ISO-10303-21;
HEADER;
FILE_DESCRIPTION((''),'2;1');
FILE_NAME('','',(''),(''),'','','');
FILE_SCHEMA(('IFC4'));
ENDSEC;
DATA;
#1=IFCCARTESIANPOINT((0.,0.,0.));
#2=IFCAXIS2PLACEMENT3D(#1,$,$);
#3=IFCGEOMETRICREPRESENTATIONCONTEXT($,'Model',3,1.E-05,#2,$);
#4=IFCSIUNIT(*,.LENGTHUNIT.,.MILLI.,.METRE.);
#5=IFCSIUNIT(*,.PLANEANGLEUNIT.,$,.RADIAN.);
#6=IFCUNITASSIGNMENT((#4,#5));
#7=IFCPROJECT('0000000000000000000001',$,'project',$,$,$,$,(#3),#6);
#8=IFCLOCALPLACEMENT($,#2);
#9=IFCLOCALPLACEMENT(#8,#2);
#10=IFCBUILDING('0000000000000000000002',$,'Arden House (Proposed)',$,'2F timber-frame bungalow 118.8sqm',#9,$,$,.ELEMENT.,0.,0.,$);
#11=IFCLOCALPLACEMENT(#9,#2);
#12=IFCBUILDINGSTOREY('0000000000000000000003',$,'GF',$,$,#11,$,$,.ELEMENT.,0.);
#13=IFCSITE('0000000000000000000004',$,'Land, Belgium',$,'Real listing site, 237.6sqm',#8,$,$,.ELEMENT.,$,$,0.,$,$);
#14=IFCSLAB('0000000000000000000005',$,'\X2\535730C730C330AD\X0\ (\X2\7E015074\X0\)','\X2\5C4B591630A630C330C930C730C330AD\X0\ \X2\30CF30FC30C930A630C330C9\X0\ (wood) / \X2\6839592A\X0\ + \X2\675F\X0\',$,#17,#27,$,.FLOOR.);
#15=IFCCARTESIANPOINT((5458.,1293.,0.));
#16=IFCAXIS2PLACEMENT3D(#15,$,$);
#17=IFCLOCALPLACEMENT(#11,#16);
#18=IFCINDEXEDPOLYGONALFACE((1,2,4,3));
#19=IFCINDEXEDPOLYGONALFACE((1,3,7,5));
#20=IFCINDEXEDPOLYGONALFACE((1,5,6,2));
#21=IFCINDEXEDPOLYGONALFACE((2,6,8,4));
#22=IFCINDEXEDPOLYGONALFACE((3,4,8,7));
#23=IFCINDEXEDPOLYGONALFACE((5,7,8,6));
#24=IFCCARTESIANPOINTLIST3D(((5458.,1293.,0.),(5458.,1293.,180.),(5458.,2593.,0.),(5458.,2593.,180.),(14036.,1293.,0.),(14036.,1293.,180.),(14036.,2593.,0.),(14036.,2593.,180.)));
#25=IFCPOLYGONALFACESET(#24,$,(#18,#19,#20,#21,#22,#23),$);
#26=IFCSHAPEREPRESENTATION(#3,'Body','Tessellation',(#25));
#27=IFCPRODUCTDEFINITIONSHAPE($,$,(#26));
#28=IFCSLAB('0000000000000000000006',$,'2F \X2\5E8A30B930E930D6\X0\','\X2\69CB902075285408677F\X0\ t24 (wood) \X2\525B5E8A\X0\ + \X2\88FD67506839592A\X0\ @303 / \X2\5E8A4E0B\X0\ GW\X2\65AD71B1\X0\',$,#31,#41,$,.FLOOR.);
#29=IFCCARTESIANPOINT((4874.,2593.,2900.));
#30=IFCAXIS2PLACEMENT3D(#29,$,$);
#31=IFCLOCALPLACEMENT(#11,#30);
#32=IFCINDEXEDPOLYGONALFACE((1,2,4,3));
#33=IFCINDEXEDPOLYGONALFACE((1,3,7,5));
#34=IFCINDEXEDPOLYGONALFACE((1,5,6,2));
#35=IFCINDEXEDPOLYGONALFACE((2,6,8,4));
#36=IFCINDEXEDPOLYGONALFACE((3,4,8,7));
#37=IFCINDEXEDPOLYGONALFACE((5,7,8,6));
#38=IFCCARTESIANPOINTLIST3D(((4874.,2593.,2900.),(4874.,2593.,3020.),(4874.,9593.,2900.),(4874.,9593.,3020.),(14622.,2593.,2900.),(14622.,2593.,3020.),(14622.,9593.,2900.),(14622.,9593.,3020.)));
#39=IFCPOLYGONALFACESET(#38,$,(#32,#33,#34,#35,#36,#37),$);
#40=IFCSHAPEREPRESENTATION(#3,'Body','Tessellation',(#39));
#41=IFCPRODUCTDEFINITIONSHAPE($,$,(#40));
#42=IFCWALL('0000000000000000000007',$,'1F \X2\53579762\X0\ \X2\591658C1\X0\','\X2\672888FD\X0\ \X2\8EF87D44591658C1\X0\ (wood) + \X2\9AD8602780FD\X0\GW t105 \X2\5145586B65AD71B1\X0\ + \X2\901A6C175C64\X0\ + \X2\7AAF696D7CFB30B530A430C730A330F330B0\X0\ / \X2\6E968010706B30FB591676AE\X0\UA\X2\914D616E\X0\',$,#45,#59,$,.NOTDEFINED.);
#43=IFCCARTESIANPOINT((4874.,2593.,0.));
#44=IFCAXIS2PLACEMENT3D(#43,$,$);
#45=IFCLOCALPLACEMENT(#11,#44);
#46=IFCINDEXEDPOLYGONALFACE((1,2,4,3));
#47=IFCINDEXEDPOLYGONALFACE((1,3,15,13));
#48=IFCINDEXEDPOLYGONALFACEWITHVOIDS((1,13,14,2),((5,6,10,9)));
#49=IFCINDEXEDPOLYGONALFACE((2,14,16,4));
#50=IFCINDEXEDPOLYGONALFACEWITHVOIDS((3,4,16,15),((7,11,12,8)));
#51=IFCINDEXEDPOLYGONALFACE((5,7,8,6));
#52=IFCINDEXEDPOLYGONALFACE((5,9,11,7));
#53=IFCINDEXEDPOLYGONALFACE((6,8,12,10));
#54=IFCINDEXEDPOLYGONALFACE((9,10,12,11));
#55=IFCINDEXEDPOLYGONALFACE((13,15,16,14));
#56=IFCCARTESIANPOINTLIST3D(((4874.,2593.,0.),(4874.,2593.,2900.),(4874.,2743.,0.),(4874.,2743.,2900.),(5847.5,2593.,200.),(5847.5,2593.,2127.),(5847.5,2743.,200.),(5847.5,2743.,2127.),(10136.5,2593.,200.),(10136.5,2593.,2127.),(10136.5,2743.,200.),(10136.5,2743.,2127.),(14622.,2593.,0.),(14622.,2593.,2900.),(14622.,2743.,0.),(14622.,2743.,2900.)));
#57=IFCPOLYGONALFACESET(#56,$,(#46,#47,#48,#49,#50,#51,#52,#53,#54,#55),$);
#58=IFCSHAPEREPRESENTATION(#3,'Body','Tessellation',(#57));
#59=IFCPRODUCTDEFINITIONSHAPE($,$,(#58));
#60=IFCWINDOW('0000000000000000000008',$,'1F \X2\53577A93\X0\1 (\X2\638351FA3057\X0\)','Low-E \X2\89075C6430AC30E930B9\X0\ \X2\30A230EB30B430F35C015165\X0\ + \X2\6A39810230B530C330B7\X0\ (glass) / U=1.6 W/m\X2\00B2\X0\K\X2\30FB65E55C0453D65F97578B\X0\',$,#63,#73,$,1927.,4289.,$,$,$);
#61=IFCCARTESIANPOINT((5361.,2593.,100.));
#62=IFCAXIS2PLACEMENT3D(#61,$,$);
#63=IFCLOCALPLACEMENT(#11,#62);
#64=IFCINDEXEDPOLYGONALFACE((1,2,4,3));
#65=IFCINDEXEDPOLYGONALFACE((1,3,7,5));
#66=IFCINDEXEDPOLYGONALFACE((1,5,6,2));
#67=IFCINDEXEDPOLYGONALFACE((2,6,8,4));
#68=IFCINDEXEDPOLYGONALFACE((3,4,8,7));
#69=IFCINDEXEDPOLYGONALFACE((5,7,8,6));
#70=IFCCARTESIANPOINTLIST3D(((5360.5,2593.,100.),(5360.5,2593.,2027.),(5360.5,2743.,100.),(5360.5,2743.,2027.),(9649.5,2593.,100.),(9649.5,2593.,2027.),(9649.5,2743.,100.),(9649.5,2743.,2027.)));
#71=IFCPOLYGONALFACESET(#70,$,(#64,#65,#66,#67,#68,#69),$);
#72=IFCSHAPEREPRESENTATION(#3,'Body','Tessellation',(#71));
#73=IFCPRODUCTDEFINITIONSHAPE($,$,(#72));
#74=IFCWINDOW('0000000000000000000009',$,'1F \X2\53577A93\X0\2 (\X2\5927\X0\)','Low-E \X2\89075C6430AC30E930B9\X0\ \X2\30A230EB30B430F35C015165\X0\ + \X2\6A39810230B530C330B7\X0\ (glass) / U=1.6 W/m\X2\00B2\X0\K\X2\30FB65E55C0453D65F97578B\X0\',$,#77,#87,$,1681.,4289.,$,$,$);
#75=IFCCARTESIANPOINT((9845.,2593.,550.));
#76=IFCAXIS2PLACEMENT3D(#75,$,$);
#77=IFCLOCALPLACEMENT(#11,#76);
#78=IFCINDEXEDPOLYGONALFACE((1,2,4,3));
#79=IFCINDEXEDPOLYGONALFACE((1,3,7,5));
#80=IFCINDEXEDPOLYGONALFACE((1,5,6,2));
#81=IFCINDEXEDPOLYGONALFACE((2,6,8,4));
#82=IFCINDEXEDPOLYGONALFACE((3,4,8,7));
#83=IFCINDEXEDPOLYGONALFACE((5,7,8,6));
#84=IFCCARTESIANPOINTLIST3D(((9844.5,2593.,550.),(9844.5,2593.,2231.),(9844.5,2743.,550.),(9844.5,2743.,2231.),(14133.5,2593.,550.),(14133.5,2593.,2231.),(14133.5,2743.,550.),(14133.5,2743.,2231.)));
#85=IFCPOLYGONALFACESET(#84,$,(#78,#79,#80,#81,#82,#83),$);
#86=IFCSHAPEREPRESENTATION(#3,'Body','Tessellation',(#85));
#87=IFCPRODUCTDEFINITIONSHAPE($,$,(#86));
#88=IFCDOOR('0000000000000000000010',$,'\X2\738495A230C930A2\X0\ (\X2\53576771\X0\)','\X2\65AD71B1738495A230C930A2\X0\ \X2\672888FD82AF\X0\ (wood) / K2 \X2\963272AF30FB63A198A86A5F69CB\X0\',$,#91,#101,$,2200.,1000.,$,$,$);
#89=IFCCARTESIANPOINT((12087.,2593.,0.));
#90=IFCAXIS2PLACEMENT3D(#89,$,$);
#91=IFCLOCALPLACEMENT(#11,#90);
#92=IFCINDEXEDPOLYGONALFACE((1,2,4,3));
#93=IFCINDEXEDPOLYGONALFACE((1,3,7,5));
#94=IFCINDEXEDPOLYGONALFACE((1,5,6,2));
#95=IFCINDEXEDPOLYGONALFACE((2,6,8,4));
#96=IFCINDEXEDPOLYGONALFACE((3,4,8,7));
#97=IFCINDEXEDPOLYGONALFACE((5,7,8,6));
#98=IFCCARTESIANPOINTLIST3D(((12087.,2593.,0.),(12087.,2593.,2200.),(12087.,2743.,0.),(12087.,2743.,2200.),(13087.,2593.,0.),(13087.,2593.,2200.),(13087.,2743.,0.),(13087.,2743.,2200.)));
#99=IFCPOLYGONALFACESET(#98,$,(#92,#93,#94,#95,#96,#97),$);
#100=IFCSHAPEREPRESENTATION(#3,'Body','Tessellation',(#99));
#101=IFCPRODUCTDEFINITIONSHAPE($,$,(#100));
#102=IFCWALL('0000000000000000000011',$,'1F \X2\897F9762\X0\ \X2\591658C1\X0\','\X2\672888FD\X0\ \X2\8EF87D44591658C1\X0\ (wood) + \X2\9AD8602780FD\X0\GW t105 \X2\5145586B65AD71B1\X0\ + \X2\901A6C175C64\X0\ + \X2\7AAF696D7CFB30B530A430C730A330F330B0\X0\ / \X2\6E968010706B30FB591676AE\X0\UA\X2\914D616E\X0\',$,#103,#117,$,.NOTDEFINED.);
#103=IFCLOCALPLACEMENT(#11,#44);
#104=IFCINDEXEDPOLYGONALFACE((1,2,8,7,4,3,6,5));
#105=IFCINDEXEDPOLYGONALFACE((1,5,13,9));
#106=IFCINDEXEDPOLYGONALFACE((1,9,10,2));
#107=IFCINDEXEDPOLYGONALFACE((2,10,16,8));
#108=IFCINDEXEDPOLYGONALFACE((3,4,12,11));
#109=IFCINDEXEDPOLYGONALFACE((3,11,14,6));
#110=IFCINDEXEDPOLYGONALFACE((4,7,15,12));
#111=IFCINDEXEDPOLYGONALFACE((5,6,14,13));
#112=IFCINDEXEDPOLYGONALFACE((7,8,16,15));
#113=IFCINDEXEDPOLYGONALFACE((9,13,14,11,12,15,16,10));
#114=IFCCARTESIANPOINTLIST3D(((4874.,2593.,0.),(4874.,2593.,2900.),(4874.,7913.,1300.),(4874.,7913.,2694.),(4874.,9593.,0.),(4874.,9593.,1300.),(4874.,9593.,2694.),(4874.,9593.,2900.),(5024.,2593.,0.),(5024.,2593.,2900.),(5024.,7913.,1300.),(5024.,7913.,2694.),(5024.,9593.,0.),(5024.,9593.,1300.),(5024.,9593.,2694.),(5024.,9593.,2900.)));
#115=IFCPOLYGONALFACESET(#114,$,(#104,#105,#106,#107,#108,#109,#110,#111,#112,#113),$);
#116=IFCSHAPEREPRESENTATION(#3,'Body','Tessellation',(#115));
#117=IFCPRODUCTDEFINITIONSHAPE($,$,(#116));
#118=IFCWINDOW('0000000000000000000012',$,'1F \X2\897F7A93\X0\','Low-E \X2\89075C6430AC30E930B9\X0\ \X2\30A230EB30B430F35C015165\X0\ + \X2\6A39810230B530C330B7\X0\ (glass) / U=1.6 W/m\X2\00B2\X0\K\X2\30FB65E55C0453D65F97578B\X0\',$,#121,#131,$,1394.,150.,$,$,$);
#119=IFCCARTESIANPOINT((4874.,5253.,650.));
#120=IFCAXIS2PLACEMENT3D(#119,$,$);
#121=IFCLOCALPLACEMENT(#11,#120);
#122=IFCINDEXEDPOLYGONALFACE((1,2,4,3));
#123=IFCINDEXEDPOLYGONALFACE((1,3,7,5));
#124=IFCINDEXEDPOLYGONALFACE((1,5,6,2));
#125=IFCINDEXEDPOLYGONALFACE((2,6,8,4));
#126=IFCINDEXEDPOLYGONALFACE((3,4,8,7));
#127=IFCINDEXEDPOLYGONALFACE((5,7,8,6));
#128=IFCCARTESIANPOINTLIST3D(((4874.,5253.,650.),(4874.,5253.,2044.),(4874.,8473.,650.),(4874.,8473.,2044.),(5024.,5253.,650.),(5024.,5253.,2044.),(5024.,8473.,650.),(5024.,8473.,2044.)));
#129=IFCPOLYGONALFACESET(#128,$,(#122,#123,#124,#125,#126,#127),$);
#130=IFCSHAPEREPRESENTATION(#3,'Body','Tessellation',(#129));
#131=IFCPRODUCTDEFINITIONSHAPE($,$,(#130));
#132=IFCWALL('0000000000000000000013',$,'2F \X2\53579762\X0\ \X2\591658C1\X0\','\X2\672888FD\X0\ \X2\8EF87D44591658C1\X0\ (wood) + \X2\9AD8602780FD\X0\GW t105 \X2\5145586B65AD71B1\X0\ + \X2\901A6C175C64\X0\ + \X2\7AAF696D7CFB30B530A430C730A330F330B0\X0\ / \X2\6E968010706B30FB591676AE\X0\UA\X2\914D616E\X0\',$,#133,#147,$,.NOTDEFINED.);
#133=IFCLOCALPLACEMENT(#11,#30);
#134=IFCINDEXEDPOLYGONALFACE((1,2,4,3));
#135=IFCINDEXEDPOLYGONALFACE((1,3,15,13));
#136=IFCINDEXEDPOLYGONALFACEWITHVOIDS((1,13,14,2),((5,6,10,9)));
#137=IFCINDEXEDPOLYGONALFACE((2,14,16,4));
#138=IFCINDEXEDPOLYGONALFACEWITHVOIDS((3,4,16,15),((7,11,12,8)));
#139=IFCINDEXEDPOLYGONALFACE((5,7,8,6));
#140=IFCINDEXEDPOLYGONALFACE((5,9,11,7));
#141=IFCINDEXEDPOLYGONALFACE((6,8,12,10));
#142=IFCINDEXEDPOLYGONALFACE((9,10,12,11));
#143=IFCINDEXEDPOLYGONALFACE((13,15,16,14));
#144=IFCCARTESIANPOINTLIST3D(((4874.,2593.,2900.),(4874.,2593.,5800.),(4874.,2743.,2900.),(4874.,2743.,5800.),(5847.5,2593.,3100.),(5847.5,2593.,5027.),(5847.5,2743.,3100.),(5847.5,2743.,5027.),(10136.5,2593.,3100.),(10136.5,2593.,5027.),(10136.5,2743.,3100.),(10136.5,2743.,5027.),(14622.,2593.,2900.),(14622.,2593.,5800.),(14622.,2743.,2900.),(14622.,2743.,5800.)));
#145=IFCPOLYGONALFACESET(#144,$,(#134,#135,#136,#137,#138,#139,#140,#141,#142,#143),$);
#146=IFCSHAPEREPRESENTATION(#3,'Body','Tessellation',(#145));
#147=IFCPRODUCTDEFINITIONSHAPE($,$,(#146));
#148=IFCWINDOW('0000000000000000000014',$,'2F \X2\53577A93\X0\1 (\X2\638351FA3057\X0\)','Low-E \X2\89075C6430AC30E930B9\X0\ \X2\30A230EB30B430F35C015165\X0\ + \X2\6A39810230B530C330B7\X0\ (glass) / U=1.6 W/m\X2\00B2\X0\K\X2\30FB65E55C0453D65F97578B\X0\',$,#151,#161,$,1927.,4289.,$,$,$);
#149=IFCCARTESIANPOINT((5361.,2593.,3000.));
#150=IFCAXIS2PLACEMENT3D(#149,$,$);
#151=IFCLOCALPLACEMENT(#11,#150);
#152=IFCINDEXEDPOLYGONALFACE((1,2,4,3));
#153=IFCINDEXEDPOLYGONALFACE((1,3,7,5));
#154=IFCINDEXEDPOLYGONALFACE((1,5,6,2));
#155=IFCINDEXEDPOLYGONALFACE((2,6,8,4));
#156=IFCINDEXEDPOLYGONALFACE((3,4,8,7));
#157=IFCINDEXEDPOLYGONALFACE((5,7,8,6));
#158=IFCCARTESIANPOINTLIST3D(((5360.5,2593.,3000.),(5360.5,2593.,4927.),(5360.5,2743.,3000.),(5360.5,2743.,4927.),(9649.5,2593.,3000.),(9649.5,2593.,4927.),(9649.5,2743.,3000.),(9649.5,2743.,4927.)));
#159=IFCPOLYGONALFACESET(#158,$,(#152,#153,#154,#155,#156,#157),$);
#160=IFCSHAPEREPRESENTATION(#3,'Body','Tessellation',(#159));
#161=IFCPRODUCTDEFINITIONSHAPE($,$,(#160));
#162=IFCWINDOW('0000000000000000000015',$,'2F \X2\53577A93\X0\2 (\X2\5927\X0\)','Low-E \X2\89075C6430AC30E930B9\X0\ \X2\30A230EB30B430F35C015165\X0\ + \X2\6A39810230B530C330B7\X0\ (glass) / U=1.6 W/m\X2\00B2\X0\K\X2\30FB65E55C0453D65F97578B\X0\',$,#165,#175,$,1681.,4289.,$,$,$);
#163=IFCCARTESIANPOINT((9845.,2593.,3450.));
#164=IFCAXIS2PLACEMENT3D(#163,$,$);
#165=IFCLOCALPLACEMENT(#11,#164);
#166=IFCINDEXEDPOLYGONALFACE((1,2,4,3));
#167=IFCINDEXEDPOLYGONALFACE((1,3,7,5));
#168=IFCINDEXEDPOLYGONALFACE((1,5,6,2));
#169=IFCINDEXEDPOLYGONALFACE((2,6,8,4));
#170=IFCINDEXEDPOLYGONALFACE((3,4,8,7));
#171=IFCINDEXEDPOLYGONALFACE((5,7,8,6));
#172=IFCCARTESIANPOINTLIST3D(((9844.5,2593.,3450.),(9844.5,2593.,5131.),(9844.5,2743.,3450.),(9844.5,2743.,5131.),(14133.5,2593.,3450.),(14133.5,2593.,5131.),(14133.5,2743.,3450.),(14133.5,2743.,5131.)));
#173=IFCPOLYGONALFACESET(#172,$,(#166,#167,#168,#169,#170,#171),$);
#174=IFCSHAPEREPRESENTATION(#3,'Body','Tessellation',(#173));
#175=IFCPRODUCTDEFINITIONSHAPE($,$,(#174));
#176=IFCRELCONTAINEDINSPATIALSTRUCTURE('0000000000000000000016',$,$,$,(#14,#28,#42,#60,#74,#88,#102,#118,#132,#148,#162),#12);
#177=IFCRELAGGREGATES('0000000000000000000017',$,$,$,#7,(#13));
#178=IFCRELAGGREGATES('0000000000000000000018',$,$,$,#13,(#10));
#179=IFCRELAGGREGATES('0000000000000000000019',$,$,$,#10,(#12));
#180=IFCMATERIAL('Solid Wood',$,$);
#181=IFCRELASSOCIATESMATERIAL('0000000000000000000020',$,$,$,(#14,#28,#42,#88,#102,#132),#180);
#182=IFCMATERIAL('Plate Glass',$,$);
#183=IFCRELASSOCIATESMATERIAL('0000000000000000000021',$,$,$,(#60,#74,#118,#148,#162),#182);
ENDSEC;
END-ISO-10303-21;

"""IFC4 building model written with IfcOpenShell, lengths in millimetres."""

from ifc_helpers import new_model, si_unit, frame, frame_2d, origin, place, context, project, spatial, rectangle, extrude, material, element, fill, save


model = new_model("IFC4")

# Units and contexts
model_context = context("Model", 3, precision=1e-05, world=origin())
ifc_project = project(units=[si_unit("LENGTHUNIT", "METRE", prefix="MILLI"), si_unit("PLANEANGLEUNIT", "RADIAN")], contexts=[model_context])

# Site, building, storey
site_placement = place(None, origin())
site = spatial("IfcSite", under=ifc_project, at=site_placement, Name="Land, Belgium", ObjectType="Real listing site, 237.6sqm", CompositionType="ELEMENT", RefElevation=0.0)
building_placement = place(site_placement, origin())
building = spatial("IfcBuilding", under=site, at=building_placement, Name="Arden House (Proposed)", ObjectType="2F timber-frame bungalow 118.8sqm", CompositionType="ELEMENT", ElevationOfRefHeight=0.0, ElevationOfTerrain=0.0)
storey_placement = place(building_placement, origin())
storey = spatial("IfcBuildingStorey", under=building, at=storey_placement, Name="GF", CompositionType="ELEMENT", Elevation=0.0)

# Slabs
ifc_material_1 = material(Name="Solid Wood")
slab_1_placement = place(storey_placement, frame((5458.0, 1293.0, 0.0)))
element("IfcSlab", 1, at=slab_1_placement, inside=storey, material=ifc_material_1, Name="南デッキ (縁側)", Description="屋外ウッドデッキ ハードウッド (wood) / 根太 + 束", PredefinedType="FLOOR", context=model_context, shape_type="SweptSolid", body=[
    extrude(rectangle(XDim=8578.0, YDim=1300.0, at=frame_2d((4289.0, 650.0))), frame((5458.0, 1293.0, 0.0)), (0.0, 0.0, 1.0), 180.0),
])
slab_2_placement = place(storey_placement, frame((4874.0, 2593.0, 2900.0)))
element("IfcSlab", 2, at=slab_2_placement, inside=storey, material=ifc_material_1, Name="2F 床スラブ", Description="構造用合板 t24 (wood) 剛床 + 製材根太 @303 / 床下 GW断熱", PredefinedType="FLOOR", context=model_context, shape_type="SweptSolid", body=[
    extrude(rectangle(XDim=9748.0, YDim=7000.0, at=frame_2d((4874.0, 3500.0))), frame((4874.0, 2593.0, 2900.0)), (0.0, 0.0, 1.0), 120.0),
])

# Wall, openings, windows, door
wall_1_placement = place(storey_placement, frame((4874.0, 2593.0, 0.0)))
wall_1 = element("IfcWall", 3, at=wall_1_placement, inside=storey, material=ifc_material_1, Name="1F 南面 外壁", Description="木製 軸組外壁 (wood) + 高性能GW t105 充填断熱 + 通気層 + 窯業系サイディング / 準耐火・外皮UA配慮", PredefinedType="NOTDEFINED", context=model_context, shape_type="SweptSolid", body=[
    extrude(rectangle(XDim=9748.0, YDim=150.0, at=frame_2d((4874.0, 75.0))), frame((4874.0, 2593.0, 0.0)), (0.0, 0.0, 1.0), 2900.0),
])
opening_1_placement = place(storey_placement, frame((5361.0, 2593.0, 100.0)))
opening_1 = element("IfcOpeningElement", 4, at=opening_1_placement, cuts=wall_1, PredefinedType="NOTDEFINED", context=model_context, shape_type="SweptSolid", body=[
    extrude(rectangle(XDim=4289.0, YDim=150.0, at=frame_2d((2144.0, 75.0))), frame((5361.0, 2593.0, 100.0)), (0.0, 0.0, 1.0), 1927.0),
])
opening_2_placement = place(storey_placement, frame((9845.0, 2593.0, 550.0)))
opening_2 = element("IfcOpeningElement", 5, at=opening_2_placement, cuts=wall_1, PredefinedType="NOTDEFINED", context=model_context, shape_type="SweptSolid", body=[
    extrude(rectangle(XDim=4289.0, YDim=150.0, at=frame_2d((2144.0, 75.0))), frame((9845.0, 2593.0, 550.0)), (0.0, 0.0, 1.0), 1681.0),
])
opening_3_placement = place(storey_placement, frame((12087.0, 2593.0, 0.0)))
opening_3 = element("IfcOpeningElement", 6, at=opening_3_placement, cuts=wall_1, PredefinedType="NOTDEFINED", context=model_context, shape_type="SweptSolid", body=[
    extrude(rectangle(XDim=1000.0, YDim=150.0, at=frame_2d((500.0, 75.0))), frame((12087.0, 2593.0, 0.0)), (0.0, 0.0, 1.0), 2200.0),
])
ifc_material_2 = material(Name="Plate Glass")
window_1_placement = place(storey_placement, frame((5361.0, 2593.0, 100.0)))
window_1 = element("IfcWindow", 7, at=window_1_placement, inside=storey, material=ifc_material_2, Name="1F 南窓1 (掃出し)", Description="Low-E 複層ガラス アルゴン封入 + 樹脂サッシ (glass) / U=1.6 W/m²K・日射取得型", OverallHeight=1927.0, OverallWidth=4289.0, context=model_context, shape_type="SweptSolid", body=[
    extrude(rectangle(XDim=4289.0, YDim=150.0, at=frame_2d((2144.0, 75.0))), frame((5361.0, 2593.0, 100.0)), (0.0, 0.0, 1.0), 1927.0),
])
fill(opening_1, window_1)
window_2_placement = place(storey_placement, frame((9845.0, 2593.0, 550.0)))
window_2 = element("IfcWindow", 8, at=window_2_placement, inside=storey, material=ifc_material_2, Name="1F 南窓2 (大)", Description="Low-E 複層ガラス アルゴン封入 + 樹脂サッシ (glass) / U=1.6 W/m²K・日射取得型", OverallHeight=1681.0, OverallWidth=4289.0, context=model_context, shape_type="SweptSolid", body=[
    extrude(rectangle(XDim=4289.0, YDim=150.0, at=frame_2d((2144.0, 75.0))), frame((9845.0, 2593.0, 550.0)), (0.0, 0.0, 1.0), 1681.0),
])
fill(opening_2, window_2)
door_placement = place(storey_placement, frame((12087.0, 2593.0, 0.0)))
door = element("IfcDoor", 9, at=door_placement, inside=storey, material=ifc_material_1, Name="玄関ドア (南東)", Description="断熱玄関ドア 木製芯 (wood) / K2 防犯・採風機構", OverallHeight=2200.0, OverallWidth=1000.0, context=model_context, shape_type="SweptSolid", body=[
    extrude(rectangle(XDim=1000.0, YDim=150.0, at=frame_2d((500.0, 75.0))), frame((12087.0, 2593.0, 0.0)), (0.0, 0.0, 1.0), 2200.0),
])
fill(opening_3, door)

# Wall, opening, window
wall_2_placement = place(storey_placement, frame((4874.0, 2593.0, 0.0)))
wall_2 = element("IfcWall", 10, at=wall_2_placement, inside=storey, material=ifc_material_1, Name="1F 西面 外壁", Description="木製 軸組外壁 (wood) + 高性能GW t105 充填断熱 + 通気層 + 窯業系サイディング / 準耐火・外皮UA配慮", PredefinedType="NOTDEFINED", context=model_context, shape_type="SweptSolid", body=[
    extrude(rectangle(XDim=150.0, YDim=7000.0, at=frame_2d((75.0, 3500.0))), frame((4874.0, 2593.0, 0.0)), (0.0, 0.0, 1.0), 2900.0),
])
opening_4_placement = place(storey_placement, frame((4874.0, 5253.0, 650.0)))
opening_4 = element("IfcOpeningElement", 11, at=opening_4_placement, cuts=wall_2, PredefinedType="NOTDEFINED", context=model_context, shape_type="SweptSolid", body=[
    extrude(rectangle(XDim=150.0, YDim=3220.0, at=frame_2d((75.0, 1610.0))), frame((4874.0, 5253.0, 650.0)), (0.0, 0.0, 1.0), 1394.0),
])
window_3_placement = place(storey_placement, frame((4874.0, 5253.0, 650.0)))
window_3 = element("IfcWindow", 12, at=window_3_placement, inside=storey, material=ifc_material_2, Name="1F 西窓", Description="Low-E 複層ガラス アルゴン封入 + 樹脂サッシ (glass) / U=1.6 W/m²K・日射取得型", OverallHeight=1394.0, OverallWidth=150.0, context=model_context, shape_type="SweptSolid", body=[
    extrude(rectangle(XDim=150.0, YDim=3220.0, at=frame_2d((75.0, 1610.0))), frame((4874.0, 5253.0, 650.0)), (0.0, 0.0, 1.0), 1394.0),
])
fill(opening_4, window_3)

# Wall, openings, windows
wall_3_placement = place(storey_placement, frame((4874.0, 2593.0, 2900.0)))
wall_3 = element("IfcWall", 13, at=wall_3_placement, inside=storey, material=ifc_material_1, Name="2F 南面 外壁", Description="木製 軸組外壁 (wood) + 高性能GW t105 充填断熱 + 通気層 + 窯業系サイディング / 準耐火・外皮UA配慮", PredefinedType="NOTDEFINED", context=model_context, shape_type="SweptSolid", body=[
    extrude(rectangle(XDim=9748.0, YDim=150.0, at=frame_2d((4874.0, 75.0))), frame((4874.0, 2593.0, 2900.0)), (0.0, 0.0, 1.0), 2900.0),
])
opening_5_placement = place(storey_placement, frame((5361.0, 2593.0, 3000.0)))
opening_5 = element("IfcOpeningElement", 14, at=opening_5_placement, cuts=wall_3, PredefinedType="NOTDEFINED", context=model_context, shape_type="SweptSolid", body=[
    extrude(rectangle(XDim=4289.0, YDim=150.0, at=frame_2d((2144.0, 75.0))), frame((5361.0, 2593.0, 3000.0)), (0.0, 0.0, 1.0), 1927.0),
])
opening_6_placement = place(storey_placement, frame((9845.0, 2593.0, 3450.0)))
opening_6 = element("IfcOpeningElement", 15, at=opening_6_placement, cuts=wall_3, PredefinedType="NOTDEFINED", context=model_context, shape_type="SweptSolid", body=[
    extrude(rectangle(XDim=4289.0, YDim=150.0, at=frame_2d((2144.0, 75.0))), frame((9845.0, 2593.0, 3450.0)), (0.0, 0.0, 1.0), 1681.0),
])
window_4_placement = place(storey_placement, frame((5361.0, 2593.0, 3000.0)))
window_4 = element("IfcWindow", 16, at=window_4_placement, inside=storey, material=ifc_material_2, Name="2F 南窓1 (掃出し)", Description="Low-E 複層ガラス アルゴン封入 + 樹脂サッシ (glass) / U=1.6 W/m²K・日射取得型", OverallHeight=1927.0, OverallWidth=4289.0, context=model_context, shape_type="SweptSolid", body=[
    extrude(rectangle(XDim=4289.0, YDim=150.0, at=frame_2d((2144.0, 75.0))), frame((5361.0, 2593.0, 3000.0)), (0.0, 0.0, 1.0), 1927.0),
])
fill(opening_5, window_4)
window_5_placement = place(storey_placement, frame((9845.0, 2593.0, 3450.0)))
window_5 = element("IfcWindow", 17, at=window_5_placement, inside=storey, material=ifc_material_2, Name="2F 南窓2 (大)", Description="Low-E 複層ガラス アルゴン封入 + 樹脂サッシ (glass) / U=1.6 W/m²K・日射取得型", OverallHeight=1681.0, OverallWidth=4289.0, context=model_context, shape_type="SweptSolid", body=[
    extrude(rectangle(XDim=4289.0, YDim=150.0, at=frame_2d((2144.0, 75.0))), frame((9845.0, 2593.0, 3450.0)), (0.0, 0.0, 1.0), 1681.0),
])
fill(opening_6, window_5)

save(model, "model.ifc")
